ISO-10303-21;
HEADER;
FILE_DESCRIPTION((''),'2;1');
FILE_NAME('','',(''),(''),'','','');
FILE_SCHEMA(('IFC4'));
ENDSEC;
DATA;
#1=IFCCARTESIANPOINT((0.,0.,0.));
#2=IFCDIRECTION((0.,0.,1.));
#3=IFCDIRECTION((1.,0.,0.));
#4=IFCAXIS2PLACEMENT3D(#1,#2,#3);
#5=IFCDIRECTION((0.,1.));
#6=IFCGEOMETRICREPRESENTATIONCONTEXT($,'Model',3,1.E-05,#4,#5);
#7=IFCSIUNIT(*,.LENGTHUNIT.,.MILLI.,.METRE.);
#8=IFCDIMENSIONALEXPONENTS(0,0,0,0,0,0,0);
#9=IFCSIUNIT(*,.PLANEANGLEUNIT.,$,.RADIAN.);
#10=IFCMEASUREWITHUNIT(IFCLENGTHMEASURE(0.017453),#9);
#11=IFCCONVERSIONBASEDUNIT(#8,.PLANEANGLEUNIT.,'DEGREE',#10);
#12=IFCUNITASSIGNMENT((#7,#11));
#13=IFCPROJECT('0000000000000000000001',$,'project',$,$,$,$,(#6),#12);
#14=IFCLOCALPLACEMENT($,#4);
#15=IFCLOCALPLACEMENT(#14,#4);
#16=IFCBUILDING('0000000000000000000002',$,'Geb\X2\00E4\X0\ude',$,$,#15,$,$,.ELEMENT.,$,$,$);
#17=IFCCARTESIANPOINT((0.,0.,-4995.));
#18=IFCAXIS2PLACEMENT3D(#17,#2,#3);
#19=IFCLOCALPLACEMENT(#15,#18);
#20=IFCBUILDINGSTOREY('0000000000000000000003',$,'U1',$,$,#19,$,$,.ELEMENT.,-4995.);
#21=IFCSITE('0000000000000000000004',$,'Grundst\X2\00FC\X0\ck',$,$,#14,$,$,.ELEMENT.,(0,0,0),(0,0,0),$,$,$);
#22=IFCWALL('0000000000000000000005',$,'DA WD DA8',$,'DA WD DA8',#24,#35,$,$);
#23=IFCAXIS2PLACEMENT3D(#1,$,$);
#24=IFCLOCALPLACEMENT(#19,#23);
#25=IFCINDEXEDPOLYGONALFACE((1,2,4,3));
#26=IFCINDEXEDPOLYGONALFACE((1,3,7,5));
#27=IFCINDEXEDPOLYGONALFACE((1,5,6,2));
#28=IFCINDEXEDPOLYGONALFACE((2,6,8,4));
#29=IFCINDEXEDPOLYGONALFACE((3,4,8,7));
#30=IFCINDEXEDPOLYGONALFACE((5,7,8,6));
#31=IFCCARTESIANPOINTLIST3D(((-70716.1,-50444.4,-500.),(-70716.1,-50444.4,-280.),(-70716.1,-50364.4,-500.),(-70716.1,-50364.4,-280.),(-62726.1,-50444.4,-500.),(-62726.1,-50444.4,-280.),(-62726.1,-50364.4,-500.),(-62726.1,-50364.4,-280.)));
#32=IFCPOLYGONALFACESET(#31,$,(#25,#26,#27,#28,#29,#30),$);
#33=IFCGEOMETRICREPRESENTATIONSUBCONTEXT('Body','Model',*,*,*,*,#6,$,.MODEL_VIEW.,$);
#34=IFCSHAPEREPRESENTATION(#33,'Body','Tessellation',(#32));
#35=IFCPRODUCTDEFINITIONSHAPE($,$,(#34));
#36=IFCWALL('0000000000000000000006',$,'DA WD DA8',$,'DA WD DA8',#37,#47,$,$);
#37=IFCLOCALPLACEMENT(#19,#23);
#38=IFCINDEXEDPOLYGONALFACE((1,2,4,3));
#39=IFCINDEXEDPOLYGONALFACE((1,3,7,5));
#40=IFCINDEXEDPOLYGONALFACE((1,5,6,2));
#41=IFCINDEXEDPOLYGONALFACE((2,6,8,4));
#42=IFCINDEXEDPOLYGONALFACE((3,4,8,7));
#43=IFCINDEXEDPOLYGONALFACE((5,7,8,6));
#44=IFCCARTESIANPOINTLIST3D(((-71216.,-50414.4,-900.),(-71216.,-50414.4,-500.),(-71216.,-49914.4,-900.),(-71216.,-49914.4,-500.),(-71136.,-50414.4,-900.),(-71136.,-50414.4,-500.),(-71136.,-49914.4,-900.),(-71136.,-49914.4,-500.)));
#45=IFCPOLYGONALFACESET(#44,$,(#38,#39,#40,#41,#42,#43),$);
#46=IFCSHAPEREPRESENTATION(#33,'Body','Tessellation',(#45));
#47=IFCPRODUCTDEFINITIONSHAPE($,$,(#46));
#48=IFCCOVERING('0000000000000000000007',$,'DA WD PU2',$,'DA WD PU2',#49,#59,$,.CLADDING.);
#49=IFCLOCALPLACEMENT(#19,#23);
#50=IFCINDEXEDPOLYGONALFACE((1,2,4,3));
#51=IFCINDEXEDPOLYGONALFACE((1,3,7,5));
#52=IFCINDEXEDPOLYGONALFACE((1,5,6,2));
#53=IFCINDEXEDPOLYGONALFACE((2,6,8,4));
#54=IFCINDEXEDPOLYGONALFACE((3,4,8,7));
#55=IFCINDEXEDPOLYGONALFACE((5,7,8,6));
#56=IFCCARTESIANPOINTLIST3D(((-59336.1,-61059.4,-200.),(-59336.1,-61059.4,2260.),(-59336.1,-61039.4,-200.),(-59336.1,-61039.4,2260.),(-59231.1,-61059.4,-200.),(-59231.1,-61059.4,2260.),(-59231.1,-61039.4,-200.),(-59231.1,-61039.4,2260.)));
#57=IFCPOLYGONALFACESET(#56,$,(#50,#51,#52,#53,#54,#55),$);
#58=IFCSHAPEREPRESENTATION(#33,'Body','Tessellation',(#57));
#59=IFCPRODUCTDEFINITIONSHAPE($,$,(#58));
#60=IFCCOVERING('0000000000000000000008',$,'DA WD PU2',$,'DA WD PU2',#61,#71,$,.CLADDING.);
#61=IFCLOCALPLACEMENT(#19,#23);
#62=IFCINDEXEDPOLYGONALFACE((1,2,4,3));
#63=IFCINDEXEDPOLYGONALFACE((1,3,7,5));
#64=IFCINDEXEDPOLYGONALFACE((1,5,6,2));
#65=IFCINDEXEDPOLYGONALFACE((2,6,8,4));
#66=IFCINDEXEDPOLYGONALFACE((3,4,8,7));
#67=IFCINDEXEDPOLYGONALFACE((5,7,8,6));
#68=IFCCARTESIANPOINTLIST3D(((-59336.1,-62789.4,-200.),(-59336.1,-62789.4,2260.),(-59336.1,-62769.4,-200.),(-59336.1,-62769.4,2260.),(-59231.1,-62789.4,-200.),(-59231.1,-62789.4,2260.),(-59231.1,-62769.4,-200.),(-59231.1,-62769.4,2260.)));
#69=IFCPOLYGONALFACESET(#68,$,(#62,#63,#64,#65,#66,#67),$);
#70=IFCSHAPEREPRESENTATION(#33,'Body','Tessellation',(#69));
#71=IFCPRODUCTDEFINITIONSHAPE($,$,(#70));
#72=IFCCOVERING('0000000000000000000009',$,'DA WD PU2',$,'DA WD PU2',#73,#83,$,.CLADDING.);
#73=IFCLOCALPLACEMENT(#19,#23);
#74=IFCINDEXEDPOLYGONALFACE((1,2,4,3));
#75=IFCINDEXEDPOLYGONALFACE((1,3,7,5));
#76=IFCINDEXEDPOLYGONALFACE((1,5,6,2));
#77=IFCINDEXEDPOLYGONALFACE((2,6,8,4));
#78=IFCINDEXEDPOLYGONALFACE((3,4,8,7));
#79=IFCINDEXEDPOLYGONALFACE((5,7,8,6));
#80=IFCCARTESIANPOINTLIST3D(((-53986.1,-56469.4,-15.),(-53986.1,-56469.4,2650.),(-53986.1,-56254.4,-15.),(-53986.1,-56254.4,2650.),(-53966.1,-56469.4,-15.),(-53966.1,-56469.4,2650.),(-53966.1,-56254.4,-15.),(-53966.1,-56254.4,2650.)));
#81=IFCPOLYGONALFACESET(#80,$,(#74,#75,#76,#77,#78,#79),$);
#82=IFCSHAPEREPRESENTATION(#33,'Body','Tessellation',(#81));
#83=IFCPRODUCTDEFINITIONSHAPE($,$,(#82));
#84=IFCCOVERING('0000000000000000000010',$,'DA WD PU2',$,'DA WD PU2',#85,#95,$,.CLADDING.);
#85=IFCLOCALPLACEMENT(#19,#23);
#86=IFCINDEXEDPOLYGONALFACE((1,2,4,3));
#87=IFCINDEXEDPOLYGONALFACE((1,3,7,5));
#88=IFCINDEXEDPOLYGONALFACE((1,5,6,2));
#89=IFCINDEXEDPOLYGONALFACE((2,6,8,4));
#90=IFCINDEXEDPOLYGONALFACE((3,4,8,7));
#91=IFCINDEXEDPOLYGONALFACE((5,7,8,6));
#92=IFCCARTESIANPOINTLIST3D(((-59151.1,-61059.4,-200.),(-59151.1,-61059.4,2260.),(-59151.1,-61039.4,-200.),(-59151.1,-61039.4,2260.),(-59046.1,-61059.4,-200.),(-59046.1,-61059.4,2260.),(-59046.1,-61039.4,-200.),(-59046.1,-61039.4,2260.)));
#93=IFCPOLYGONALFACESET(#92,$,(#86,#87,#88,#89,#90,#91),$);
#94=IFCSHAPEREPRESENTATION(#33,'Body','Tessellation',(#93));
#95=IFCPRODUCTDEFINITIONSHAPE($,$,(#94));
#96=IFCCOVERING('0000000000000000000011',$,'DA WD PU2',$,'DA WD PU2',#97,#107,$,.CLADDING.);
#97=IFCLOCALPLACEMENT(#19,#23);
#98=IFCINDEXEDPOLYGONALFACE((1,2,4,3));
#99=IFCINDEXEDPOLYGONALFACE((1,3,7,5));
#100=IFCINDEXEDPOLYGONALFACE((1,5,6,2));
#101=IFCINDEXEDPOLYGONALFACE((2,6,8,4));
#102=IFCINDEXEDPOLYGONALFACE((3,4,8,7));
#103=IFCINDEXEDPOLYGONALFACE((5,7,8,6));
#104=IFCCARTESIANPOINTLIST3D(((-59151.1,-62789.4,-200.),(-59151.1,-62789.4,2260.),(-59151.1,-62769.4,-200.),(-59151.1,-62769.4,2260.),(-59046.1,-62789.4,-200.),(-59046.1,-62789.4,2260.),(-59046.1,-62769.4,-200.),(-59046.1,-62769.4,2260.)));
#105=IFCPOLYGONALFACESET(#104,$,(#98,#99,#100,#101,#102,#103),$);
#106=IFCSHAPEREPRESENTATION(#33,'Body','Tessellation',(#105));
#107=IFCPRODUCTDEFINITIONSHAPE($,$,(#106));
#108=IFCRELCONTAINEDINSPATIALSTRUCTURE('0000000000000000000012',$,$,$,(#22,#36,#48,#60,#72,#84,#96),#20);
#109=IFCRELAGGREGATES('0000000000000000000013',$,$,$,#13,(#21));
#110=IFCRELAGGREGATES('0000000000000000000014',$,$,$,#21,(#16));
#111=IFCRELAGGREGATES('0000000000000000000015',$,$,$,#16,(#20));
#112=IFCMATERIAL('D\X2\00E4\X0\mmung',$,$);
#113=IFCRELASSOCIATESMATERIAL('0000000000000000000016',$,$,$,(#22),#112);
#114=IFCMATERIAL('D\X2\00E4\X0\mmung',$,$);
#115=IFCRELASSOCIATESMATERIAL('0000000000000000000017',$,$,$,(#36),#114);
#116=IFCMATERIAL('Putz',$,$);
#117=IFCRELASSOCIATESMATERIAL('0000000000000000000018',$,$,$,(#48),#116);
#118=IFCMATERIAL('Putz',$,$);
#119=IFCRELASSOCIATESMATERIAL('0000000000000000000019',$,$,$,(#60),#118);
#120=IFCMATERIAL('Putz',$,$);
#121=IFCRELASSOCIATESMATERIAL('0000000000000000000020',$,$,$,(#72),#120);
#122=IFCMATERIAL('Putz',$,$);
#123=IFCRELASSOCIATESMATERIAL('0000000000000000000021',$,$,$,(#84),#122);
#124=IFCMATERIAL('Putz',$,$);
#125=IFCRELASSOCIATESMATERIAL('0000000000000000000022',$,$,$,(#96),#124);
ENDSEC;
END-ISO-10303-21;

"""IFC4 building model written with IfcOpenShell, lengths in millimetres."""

from ifc_helpers import new_model, entity, si_unit, converted_unit, direction, frame, origin_with_axes, place, context, subcontext, project, spatial, line, indexed_curve, outline, extrude, material, element, save


model = new_model("IFC4")

# Units and contexts
model_context = context("Model", 3, precision=1e-05, world=origin_with_axes(), true_north=direction((0.0, 1.0)))
body_context = subcontext(model_context, "Body", "Model", "MODEL_VIEW")
ifc_project = project(units=[si_unit("LENGTHUNIT", "METRE", prefix="MILLI"), converted_unit("PLANEANGLEUNIT", "DEGREE", entity("IfcLengthMeasure", 0.017453), si_unit("PLANEANGLEUNIT", "RADIAN"), dimensions=[0, 0, 0, 0, 0, 0, 0])], contexts=[model_context])

# Site, building, storey
site_placement = place(None, origin_with_axes())
site = spatial("IfcSite", under=ifc_project, at=site_placement, Name="Grundstück", CompositionType="ELEMENT", RefLatitude=(0, 0, 0), RefLongitude=(0, 0, 0))
building_placement = place(site_placement, origin_with_axes())
building = spatial("IfcBuilding", under=site, at=building_placement, Name="Gebäude", CompositionType="ELEMENT")
storey_placement = place(building_placement, frame((0.0, 0.0, -4995.0), z_axis=(0.0, 0.0, 1.0), x_axis=(1.0, 0.0, 0.0)))
storey = spatial("IfcBuildingStorey", under=building, at=storey_placement, Name="U1", CompositionType="ELEMENT", Elevation=-4995.0)

# Walls
ifc_material_1 = material(Name="Dämmung")
wall_1_placement = place(storey_placement, frame((-70716.1, -50404.4, -500.0), z_axis=(0.0, 0.0, 1.0), x_axis=(1.0, 0.0, 0.0)))
element("IfcWall", 1, at=wall_1_placement, inside=storey, material=ifc_material_1, Name="DA WD DA8", ObjectType="DA WD DA8", context=body_context, shape_type="SweptSolid", body=[
    extrude(outline(indexed_curve([(0.0, -40.0), (0.0, 40.0), (7990.0, 40.0), (7990.0, -40.0)], segments=[line(1, 2), line(2, 3), line(3, 4), line(4, 1)])), origin_with_axes(), (0.0, 0.0, 1.0), 220.0),
])
ifc_material_2 = material(Name="Dämmung")
wall_2_placement = place(storey_placement, frame((-71176.0, -50414.4, -900.0), z_axis=(0.0, 0.0, 1.0), x_axis=(0.0, 1.0, 0.0)))
element("IfcWall", 2, at=wall_2_placement, inside=storey, material=ifc_material_2, Name="DA WD DA8", ObjectType="DA WD DA8", context=body_context, shape_type="SweptSolid", body=[
    extrude(outline(indexed_curve([(0.0, -40.0), (0.0, 40.0), (500.0, 40.0), (500.0, -40.0)], segments=[line(1, 2), line(2, 3), line(3, 4), line(4, 1)])), origin_with_axes(), (0.0, 0.0, 1.0), 400.0),
])

# Coverings
ifc_material_3 = material(Name="Putz")
covering_1_placement = place(storey_placement, frame((-59231.1, -61049.4, -200.0), z_axis=(0.0, 0.0, 1.0), x_axis=(-1.0, 0.0, 0.0)))
element("IfcCovering", 3, at=covering_1_placement, inside=storey, material=ifc_material_3, Name="DA WD PU2", ObjectType="DA WD PU2", PredefinedType="CLADDING", context=body_context, shape_type="SweptSolid", body=[
    extrude(outline(indexed_curve([(0.0, -10.0), (0.0, 10.0), (105.0, 10.0), (105.0, -10.0)], segments=[line(1, 2), line(2, 3), line(3, 4), line(4, 1)])), origin_with_axes(), (0.0, 0.0, 1.0), 2460.0),
])
ifc_material_4 = material(Name="Putz")
covering_2_placement = place(storey_placement, frame((-59231.1, -62779.4, -200.0), z_axis=(0.0, 0.0, 1.0), x_axis=(-1.0, 0.0, 0.0)))
element("IfcCovering", 4, at=covering_2_placement, inside=storey, material=ifc_material_4, Name="DA WD PU2", ObjectType="DA WD PU2", PredefinedType="CLADDING", context=body_context, shape_type="SweptSolid", body=[
    extrude(outline(indexed_curve([(0.0, -10.0), (0.0, 10.0), (105.0, 10.0), (105.0, -10.0)], segments=[line(1, 2), line(2, 3), line(3, 4), line(4, 1)])), origin_with_axes(), (0.0, 0.0, 1.0), 2460.0),
])
ifc_material_5 = material(Name="Putz")
covering_3_placement = place(storey_placement, frame((-53976.1, -56469.4, -15.0), z_axis=(0.0, 0.0, 1.0), x_axis=(0.0, 1.0, 0.0)))
element("IfcCovering", 5, at=covering_3_placement, inside=storey, material=ifc_material_5, Name="DA WD PU2", ObjectType="DA WD PU2", PredefinedType="CLADDING", context=body_context, shape_type="SweptSolid", body=[
    extrude(outline(indexed_curve([(0.0, -10.0), (0.0, 10.0), (215.0, 10.0), (215.0, -10.0)], segments=[line(1, 2), line(2, 3), line(3, 4), line(4, 1)])), origin_with_axes(), (0.0, 0.0, 1.0), 2665.0),
])
ifc_material_6 = material(Name="Putz")
covering_4_placement = place(storey_placement, frame((-59046.1, -61049.4, -200.0), z_axis=(0.0, 0.0, 1.0), x_axis=(-1.0, 0.0, 0.0)))
element("IfcCovering", 6, at=covering_4_placement, inside=storey, material=ifc_material_6, Name="DA WD PU2", ObjectType="DA WD PU2", PredefinedType="CLADDING", context=body_context, shape_type="SweptSolid", body=[
    extrude(outline(indexed_curve([(0.0, -10.0), (0.0, 10.0), (105.0, 10.0), (105.0, -10.0)], segments=[line(1, 2), line(2, 3), line(3, 4), line(4, 1)])), origin_with_axes(), (0.0, 0.0, 1.0), 2460.0),
])
ifc_material_7 = material(Name="Putz")
covering_5_placement = place(storey_placement, frame((-59046.1, -62779.4, -200.0), z_axis=(0.0, 0.0, 1.0), x_axis=(-1.0, 0.0, 0.0)))
element("IfcCovering", 7, at=covering_5_placement, inside=storey, material=ifc_material_7, Name="DA WD PU2", ObjectType="DA WD PU2", PredefinedType="CLADDING", context=body_context, shape_type="SweptSolid", body=[
    extrude(outline(indexed_curve([(0.0, -10.0), (0.0, 10.0), (105.0, 10.0), (105.0, -10.0)], segments=[line(1, 2), line(2, 3), line(3, 4), line(4, 1)])), origin_with_axes(), (0.0, 0.0, 1.0), 2460.0),
])

save(model, "model.ifc")
